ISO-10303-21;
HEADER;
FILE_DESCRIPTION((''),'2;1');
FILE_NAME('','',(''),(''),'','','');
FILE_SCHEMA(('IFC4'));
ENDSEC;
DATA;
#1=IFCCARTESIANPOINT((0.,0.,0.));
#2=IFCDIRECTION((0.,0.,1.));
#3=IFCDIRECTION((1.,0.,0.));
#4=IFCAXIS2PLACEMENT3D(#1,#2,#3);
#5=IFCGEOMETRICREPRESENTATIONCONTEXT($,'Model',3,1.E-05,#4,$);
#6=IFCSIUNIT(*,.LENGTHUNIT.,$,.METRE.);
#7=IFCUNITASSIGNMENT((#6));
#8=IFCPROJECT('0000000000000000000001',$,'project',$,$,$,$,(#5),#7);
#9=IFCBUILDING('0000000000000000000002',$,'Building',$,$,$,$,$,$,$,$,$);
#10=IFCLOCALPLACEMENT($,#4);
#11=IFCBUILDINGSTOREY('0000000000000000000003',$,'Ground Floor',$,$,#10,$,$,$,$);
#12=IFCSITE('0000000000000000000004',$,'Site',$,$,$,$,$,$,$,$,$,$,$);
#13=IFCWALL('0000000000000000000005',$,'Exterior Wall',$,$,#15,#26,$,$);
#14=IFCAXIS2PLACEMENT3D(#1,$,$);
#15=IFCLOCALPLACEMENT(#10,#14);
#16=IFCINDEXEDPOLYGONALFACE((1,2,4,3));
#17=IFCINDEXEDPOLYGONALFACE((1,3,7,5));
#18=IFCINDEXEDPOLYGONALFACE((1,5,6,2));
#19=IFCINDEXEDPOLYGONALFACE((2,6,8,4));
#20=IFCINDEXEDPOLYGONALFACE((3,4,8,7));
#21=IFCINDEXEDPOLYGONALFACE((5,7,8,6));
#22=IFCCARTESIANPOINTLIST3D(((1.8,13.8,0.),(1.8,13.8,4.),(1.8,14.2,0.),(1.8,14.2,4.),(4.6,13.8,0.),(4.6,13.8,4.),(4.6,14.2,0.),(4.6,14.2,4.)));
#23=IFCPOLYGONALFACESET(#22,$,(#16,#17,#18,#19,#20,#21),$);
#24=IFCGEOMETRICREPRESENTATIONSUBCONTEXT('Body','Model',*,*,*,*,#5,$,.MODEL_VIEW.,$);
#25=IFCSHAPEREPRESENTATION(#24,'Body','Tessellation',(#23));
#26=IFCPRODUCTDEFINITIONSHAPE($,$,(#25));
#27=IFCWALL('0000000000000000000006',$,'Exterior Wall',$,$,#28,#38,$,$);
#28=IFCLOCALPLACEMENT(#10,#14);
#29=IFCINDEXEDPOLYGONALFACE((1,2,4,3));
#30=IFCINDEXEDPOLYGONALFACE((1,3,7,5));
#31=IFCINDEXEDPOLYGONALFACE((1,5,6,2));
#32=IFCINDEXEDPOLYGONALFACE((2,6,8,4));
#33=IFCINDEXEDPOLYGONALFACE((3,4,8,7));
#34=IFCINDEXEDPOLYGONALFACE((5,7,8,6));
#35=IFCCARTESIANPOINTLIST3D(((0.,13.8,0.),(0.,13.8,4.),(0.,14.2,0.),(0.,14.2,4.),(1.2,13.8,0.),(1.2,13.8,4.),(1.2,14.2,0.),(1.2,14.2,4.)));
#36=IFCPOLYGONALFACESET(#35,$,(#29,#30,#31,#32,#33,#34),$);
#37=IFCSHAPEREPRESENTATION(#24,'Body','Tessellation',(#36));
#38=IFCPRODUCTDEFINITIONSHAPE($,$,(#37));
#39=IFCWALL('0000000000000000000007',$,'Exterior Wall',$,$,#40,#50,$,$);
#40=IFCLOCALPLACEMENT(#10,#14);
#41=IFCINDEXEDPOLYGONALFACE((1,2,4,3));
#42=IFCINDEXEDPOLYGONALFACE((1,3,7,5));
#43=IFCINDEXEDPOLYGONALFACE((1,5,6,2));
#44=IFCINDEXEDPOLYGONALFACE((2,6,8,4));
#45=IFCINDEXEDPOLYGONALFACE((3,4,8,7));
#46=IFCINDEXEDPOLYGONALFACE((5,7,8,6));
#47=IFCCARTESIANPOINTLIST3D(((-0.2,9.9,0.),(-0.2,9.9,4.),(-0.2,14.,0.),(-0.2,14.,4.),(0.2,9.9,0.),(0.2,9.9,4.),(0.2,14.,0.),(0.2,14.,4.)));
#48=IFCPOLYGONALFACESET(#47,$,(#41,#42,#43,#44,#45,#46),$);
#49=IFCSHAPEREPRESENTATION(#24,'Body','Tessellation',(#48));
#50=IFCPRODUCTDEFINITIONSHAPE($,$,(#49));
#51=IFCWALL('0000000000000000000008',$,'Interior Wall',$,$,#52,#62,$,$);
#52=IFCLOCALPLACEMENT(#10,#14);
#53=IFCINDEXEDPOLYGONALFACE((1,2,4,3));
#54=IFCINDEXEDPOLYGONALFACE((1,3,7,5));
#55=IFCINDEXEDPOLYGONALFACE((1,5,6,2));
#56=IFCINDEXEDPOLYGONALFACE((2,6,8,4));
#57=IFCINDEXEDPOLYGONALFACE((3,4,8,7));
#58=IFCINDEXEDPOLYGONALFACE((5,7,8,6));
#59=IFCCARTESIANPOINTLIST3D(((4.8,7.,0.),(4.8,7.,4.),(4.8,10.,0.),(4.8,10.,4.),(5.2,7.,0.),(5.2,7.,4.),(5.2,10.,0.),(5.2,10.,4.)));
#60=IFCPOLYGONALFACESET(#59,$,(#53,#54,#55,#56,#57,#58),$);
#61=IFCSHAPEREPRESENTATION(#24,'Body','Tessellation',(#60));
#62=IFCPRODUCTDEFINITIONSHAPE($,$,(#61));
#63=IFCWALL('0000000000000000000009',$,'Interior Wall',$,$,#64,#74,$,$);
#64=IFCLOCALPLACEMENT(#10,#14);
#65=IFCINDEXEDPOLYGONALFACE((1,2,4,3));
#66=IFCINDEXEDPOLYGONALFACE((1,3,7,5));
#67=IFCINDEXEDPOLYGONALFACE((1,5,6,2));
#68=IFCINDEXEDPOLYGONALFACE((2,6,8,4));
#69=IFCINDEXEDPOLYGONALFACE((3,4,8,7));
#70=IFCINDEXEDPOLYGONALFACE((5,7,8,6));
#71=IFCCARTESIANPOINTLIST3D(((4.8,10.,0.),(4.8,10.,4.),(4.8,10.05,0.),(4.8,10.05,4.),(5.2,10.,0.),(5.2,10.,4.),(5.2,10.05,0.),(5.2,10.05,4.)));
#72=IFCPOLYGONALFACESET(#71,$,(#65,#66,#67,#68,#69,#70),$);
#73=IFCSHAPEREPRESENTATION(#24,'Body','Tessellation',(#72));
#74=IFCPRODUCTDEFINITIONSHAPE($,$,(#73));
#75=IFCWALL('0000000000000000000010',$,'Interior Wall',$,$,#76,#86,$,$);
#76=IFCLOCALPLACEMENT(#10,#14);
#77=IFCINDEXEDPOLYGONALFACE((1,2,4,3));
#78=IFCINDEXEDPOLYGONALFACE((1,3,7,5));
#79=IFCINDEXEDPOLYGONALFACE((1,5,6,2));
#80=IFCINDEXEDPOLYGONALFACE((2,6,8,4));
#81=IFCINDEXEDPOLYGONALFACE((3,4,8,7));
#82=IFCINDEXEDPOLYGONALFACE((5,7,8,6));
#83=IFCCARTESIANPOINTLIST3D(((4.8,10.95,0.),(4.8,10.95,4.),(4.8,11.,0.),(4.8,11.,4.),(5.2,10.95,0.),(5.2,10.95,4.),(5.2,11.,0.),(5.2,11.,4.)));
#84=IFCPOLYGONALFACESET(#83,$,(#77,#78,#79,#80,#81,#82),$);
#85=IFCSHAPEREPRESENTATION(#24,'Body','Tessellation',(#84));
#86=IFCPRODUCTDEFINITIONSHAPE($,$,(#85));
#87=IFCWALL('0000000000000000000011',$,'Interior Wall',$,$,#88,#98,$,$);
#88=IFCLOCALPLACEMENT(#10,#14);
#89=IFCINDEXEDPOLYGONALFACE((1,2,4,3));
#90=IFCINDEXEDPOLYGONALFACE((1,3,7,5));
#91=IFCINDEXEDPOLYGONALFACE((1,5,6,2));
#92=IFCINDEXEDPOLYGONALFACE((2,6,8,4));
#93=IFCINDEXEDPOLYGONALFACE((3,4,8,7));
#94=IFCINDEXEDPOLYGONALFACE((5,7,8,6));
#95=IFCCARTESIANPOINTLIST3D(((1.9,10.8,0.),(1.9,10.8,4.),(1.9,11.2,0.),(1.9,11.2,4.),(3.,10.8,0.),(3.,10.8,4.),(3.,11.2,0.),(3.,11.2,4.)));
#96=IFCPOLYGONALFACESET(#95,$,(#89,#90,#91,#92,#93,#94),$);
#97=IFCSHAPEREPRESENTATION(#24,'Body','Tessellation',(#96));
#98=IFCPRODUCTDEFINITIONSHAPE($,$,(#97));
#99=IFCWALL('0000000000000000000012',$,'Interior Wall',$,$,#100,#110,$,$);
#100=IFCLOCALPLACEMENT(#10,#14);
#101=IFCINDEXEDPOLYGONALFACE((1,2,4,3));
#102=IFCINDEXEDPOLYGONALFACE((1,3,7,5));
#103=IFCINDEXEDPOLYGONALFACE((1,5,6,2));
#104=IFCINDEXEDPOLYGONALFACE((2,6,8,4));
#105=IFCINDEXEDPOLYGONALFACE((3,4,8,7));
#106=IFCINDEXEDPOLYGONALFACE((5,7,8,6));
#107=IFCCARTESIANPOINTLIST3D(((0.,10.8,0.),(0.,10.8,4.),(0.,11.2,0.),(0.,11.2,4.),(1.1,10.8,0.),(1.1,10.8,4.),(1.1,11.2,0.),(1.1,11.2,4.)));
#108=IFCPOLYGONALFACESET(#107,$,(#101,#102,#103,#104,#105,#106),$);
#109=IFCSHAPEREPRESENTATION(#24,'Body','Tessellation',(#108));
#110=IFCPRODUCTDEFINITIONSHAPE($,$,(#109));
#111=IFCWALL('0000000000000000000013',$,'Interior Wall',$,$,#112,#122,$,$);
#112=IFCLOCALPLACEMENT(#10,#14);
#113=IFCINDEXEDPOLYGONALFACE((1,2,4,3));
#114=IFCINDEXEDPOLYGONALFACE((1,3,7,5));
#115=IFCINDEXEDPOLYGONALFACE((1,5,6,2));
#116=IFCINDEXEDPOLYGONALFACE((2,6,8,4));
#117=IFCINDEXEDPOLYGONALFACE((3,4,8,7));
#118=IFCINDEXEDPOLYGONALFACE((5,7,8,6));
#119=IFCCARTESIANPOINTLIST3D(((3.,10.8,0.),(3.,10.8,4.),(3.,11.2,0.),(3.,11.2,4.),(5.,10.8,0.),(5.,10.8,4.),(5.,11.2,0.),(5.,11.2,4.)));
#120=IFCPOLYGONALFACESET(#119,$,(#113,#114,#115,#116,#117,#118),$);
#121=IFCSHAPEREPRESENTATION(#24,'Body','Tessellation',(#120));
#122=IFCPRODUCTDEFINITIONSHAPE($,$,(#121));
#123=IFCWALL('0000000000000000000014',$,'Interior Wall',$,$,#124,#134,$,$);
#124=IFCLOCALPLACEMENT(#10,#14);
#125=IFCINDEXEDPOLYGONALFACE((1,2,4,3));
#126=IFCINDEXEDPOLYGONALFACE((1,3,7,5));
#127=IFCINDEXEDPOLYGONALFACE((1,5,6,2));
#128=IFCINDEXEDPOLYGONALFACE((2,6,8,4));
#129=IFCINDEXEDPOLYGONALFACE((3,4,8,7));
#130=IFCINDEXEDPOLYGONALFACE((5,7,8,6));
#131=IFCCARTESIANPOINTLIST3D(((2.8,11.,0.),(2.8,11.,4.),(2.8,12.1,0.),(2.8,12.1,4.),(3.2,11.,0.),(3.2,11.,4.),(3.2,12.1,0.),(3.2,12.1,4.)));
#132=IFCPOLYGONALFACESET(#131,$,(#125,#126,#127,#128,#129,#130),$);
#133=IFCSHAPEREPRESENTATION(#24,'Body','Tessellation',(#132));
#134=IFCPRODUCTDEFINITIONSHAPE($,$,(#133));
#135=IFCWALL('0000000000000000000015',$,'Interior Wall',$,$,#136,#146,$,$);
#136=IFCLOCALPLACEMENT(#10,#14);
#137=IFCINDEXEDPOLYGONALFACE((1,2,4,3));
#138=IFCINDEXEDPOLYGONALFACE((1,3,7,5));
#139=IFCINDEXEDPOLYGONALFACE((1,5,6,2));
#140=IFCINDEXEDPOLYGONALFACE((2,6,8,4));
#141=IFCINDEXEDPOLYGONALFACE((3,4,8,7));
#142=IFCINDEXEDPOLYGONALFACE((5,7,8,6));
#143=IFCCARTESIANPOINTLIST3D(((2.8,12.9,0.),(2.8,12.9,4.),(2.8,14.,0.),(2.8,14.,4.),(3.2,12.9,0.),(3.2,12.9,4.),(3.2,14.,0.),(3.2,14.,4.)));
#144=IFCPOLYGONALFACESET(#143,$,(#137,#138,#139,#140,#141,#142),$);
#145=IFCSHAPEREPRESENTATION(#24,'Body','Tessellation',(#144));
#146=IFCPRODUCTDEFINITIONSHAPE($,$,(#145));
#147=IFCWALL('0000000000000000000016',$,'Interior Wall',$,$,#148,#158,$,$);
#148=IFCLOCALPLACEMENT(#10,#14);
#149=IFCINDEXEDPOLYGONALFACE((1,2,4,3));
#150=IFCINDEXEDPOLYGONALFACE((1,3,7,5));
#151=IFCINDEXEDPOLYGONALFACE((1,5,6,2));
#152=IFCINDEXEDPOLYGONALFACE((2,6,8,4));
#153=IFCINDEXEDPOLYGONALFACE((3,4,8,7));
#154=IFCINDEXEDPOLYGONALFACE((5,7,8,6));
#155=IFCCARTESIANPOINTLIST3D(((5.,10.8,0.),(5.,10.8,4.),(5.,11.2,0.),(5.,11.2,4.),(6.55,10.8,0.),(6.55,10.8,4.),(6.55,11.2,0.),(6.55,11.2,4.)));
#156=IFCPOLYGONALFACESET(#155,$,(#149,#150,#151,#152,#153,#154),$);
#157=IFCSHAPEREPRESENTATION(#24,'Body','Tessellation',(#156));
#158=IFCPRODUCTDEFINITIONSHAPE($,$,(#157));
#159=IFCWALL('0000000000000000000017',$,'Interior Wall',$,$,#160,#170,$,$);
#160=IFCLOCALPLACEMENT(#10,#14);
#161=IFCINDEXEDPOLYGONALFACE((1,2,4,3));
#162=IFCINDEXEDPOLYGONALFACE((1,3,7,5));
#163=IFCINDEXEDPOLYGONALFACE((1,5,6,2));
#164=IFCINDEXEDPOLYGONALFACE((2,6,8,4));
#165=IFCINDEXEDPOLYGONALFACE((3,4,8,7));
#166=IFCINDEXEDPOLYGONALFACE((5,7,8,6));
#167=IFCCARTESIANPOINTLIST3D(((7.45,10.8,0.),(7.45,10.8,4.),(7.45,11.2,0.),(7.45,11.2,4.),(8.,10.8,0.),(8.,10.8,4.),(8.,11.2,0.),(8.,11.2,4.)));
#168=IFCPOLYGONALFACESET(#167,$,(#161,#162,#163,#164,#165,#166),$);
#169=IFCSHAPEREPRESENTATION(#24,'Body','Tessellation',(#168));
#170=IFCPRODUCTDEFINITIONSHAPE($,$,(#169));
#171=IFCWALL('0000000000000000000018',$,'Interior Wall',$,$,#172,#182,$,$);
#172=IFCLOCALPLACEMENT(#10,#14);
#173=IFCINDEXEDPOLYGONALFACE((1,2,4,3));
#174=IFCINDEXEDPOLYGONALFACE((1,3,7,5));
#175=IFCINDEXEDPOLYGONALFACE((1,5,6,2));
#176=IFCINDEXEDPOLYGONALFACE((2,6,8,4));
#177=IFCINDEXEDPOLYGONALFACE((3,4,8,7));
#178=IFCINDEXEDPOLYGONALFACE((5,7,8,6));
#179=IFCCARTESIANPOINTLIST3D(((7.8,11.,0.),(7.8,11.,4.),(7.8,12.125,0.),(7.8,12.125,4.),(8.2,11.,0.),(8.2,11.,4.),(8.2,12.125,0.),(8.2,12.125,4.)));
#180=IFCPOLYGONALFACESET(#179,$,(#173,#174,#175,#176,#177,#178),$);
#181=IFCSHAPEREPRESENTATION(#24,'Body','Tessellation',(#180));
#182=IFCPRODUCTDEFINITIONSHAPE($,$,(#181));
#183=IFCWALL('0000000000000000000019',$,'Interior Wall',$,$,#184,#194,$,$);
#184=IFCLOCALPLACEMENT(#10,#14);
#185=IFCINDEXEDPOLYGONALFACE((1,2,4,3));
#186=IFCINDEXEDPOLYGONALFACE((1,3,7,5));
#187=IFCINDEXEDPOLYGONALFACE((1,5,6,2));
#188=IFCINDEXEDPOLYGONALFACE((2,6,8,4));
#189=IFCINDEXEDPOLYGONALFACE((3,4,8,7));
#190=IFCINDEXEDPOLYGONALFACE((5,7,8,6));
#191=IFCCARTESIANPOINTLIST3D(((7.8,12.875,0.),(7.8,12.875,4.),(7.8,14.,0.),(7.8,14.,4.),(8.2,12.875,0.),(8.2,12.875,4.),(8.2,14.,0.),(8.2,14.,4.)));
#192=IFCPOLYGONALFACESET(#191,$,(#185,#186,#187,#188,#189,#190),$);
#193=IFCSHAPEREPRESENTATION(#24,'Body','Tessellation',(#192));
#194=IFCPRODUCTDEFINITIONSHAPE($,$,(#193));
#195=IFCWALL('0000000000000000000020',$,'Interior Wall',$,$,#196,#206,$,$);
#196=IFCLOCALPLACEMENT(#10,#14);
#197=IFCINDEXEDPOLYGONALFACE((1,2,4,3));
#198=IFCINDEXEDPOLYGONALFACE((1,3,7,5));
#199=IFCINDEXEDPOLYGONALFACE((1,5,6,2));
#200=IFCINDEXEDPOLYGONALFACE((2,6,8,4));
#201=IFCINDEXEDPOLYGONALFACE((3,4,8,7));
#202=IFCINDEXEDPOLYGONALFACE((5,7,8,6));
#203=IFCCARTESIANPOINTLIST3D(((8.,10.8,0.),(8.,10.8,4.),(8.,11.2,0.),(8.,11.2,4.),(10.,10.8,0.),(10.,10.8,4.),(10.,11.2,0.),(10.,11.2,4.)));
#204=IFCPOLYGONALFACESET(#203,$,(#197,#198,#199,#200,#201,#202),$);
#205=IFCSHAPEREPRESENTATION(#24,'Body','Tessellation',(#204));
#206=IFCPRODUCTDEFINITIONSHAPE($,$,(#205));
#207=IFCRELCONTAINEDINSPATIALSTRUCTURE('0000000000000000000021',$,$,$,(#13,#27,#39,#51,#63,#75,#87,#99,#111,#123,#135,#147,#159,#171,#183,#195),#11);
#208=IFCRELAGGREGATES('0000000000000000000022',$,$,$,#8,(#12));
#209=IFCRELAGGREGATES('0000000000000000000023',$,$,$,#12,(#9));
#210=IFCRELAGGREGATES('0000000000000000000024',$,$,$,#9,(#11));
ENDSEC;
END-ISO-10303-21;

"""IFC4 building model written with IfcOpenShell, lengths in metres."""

from ifc_helpers import new_model, si_unit, frame, origin_with_axes, place, context, subcontext, project, spatial, indexed_curve, outline, extrude, element, save


model = new_model("IFC4")

# Units and contexts
model_context = context("Model", 3, precision=1e-05, world=origin_with_axes())
body_context = subcontext(model_context, "Body", "Model", "MODEL_VIEW")
ifc_project = project(units=[si_unit("LENGTHUNIT", "METRE")], contexts=[model_context])

# Site, building, storey
site = spatial("IfcSite", under=ifc_project, Name="Site")
building = spatial("IfcBuilding", under=site, Name="Building")
storey_placement = place(None, origin_with_axes())
storey = spatial("IfcBuildingStorey", under=building, at=storey_placement, Name="Ground Floor")

# Walls
wall_1_placement = place(storey_placement, frame((4.6, 14.0, 0.0), z_axis=(0.0, 0.0, 1.0), x_axis=(-1.0, 0.0, 0.0)))
element("IfcWall", 1, at=wall_1_placement, inside=storey, Name="Exterior Wall", context=body_context, shape_type="SweptSolid", body=[
    extrude(outline(indexed_curve([(0.0, 0.0), (0.0, 0.4), (2.8, 0.4), (2.8, 0.0), (0.0, 0.0)], self_intersect=False)), frame((0.0, -0.2, 0.0), z_axis=(0.0, 0.0, 1.0), x_axis=(1.0, 0.0, 0.0)), (0.0, 0.0, 1.0), 4.0),
])
wall_2_placement = place(storey_placement, frame((1.2, 14.0, 0.0), z_axis=(0.0, 0.0, 1.0), x_axis=(-1.0, 0.0, 0.0)))
element("IfcWall", 2, at=wall_2_placement, inside=storey, Name="Exterior Wall", context=body_context, shape_type="SweptSolid", body=[
    extrude(outline(indexed_curve([(0.0, 0.0), (0.0, 0.4), (1.2, 0.4), (1.2, 0.0), (0.0, 0.0)], self_intersect=False)), frame((0.0, -0.2, 0.0), z_axis=(0.0, 0.0, 1.0), x_axis=(1.0, 0.0, 0.0)), (0.0, 0.0, 1.0), 4.0),
])
wall_3_placement = place(storey_placement, frame((0.0, 14.0, 0.0), z_axis=(0.0, 0.0, 1.0), x_axis=(0.0, -1.0, 0.0)))
element("IfcWall", 3, at=wall_3_placement, inside=storey, Name="Exterior Wall", context=body_context, shape_type="SweptSolid", body=[
    extrude(outline(indexed_curve([(0.0, 0.0), (0.0, 0.4), (4.1, 0.4), (4.1, 0.0), (0.0, 0.0)], self_intersect=False)), frame((0.0, -0.2, 0.0), z_axis=(0.0, 0.0, 1.0), x_axis=(1.0, 0.0, 0.0)), (0.0, 0.0, 1.0), 4.0),
])
wall_4_placement = place(storey_placement, frame((5.0, 10.0, 0.0), z_axis=(0.0, 0.0, 1.0), x_axis=(0.0, -1.0, 0.0)))
element("IfcWall", 4, at=wall_4_placement, inside=storey, Name="Interior Wall", context=body_context, shape_type="SweptSolid", body=[
    extrude(outline(indexed_curve([(0.0, 0.0), (0.0, 0.4), (3.0, 0.4), (3.0, 0.0), (0.0, 0.0)], self_intersect=False)), frame((0.0, -0.2, 0.0), z_axis=(0.0, 0.0, 1.0), x_axis=(1.0, 0.0, 0.0)), (0.0, 0.0, 1.0), 4.0),
])
for number, where, z_axis, x_axis, name in (
    (5, (5.0, 10.0, 0.0), (0.0, 0.0, 1.0), (0.0, 1.0, 0.0), "Interior Wall"),
    (6, (5.0, 10.95, 0.0), (0.0, 0.0, 1.0), (0.0, 1.0, 0.0), "Interior Wall"),
):
    element("IfcWall", number, at=place(storey_placement, frame(where, z_axis=z_axis, x_axis=x_axis)), inside=storey, Name=name, context=body_context, shape_type="SweptSolid", body=[
        extrude(outline(indexed_curve([(0.0, 0.0), (0.0, 0.4), (0.05, 0.4), (0.05, 0.0), (0.0, 0.0)], self_intersect=False)), frame((0.0, -0.2, 0.0), z_axis=(0.0, 0.0, 1.0), x_axis=(1.0, 0.0, 0.0)), (0.0, 0.0, 1.0), 4.0),
    ])
for number, where, z_axis, x_axis, name in (
    (7, (3.0, 11.0, 0.0), (0.0, 0.0, 1.0), (-1.0, 0.0, 0.0), "Interior Wall"),
    (8, (1.1, 11.0, 0.0), (0.0, 0.0, 1.0), (-1.0, 0.0, 0.0), "Interior Wall"),
):
    element("IfcWall", number, at=place(storey_placement, frame(where, z_axis=z_axis, x_axis=x_axis)), inside=storey, Name=name, context=body_context, shape_type="SweptSolid", body=[
        extrude(outline(indexed_curve([(0.0, 0.0), (0.0, 0.4), (1.1, 0.4), (1.1, 0.0), (0.0, 0.0)], self_intersect=False)), frame((0.0, -0.2, 0.0), z_axis=(0.0, 0.0, 1.0), x_axis=(1.0, 0.0, 0.0)), (0.0, 0.0, 1.0), 4.0),
    ])
wall_5_placement = place(storey_placement, frame((5.0, 11.0, 0.0), z_axis=(0.0, 0.0, 1.0), x_axis=(-1.0, 0.0, 0.0)))
element("IfcWall", 9, at=wall_5_placement, inside=storey, Name="Interior Wall", context=body_context, shape_type="SweptSolid", body=[
    extrude(outline(indexed_curve([(0.0, 0.0), (0.0, 0.4), (2.0, 0.4), (2.0, 0.0), (0.0, 0.0)], self_intersect=False)), frame((0.0, -0.2, 0.0), z_axis=(0.0, 0.0, 1.0), x_axis=(1.0, 0.0, 0.0)), (0.0, 0.0, 1.0), 4.0),
])
for number, where, z_axis, x_axis, name in (
    (10, (3.0, 11.0, 0.0), (0.0, 0.0, 1.0), (0.0, 1.0, 0.0), "Interior Wall"),
    (11, (3.0, 12.9, 0.0), (0.0, 0.0, 1.0), (0.0, 1.0, 0.0), "Interior Wall"),
):
    element("IfcWall", number, at=place(storey_placement, frame(where, z_axis=z_axis, x_axis=x_axis)), inside=storey, Name=name, context=body_context, shape_type="SweptSolid", body=[
        extrude(outline(indexed_curve([(0.0, 0.0), (0.0, 0.4), (1.1, 0.4), (1.1, 0.0), (0.0, 0.0)], self_intersect=False)), frame((0.0, -0.2, 0.0), z_axis=(0.0, 0.0, 1.0), x_axis=(1.0, 0.0, 0.0)), (0.0, 0.0, 1.0), 4.0),
    ])
wall_6_placement = place(storey_placement, frame((5.0, 11.0, 0.0), z_axis=(0.0, 0.0, 1.0), x_axis=(1.0, 0.0, 0.0)))
element("IfcWall", 12, at=wall_6_placement, inside=storey, Name="Interior Wall", context=body_context, shape_type="SweptSolid", body=[
    extrude(outline(indexed_curve([(0.0, 0.0), (0.0, 0.4), (1.55, 0.4), (1.55, 0.0), (0.0, 0.0)], self_intersect=False)), frame((0.0, -0.2, 0.0), z_axis=(0.0, 0.0, 1.0), x_axis=(1.0, 0.0, 0.0)), (0.0, 0.0, 1.0), 4.0),
])
wall_7_placement = place(storey_placement, frame((7.45, 11.0, 0.0), z_axis=(0.0, 0.0, 1.0), x_axis=(1.0, 0.0, 0.0)))
element("IfcWall", 13, at=wall_7_placement, inside=storey, Name="Interior Wall", context=body_context, shape_type="SweptSolid", body=[
    extrude(outline(indexed_curve([(0.0, 0.0), (0.0, 0.4), (0.55, 0.4), (0.55, 0.0), (0.0, 0.0)], self_intersect=False)), frame((0.0, -0.2, 0.0), z_axis=(0.0, 0.0, 1.0), x_axis=(1.0, 0.0, 0.0)), (0.0, 0.0, 1.0), 4.0),
])
for number, where, z_axis, x_axis, name in (
    (14, (8.0, 11.0, 0.0), (0.0, 0.0, 1.0), (0.0, 1.0, 0.0), "Interior Wall"),
    (15, (8.0, 12.875, 0.0), (0.0, 0.0, 1.0), (0.0, 1.0, 0.0), "Interior Wall"),
):
    element("IfcWall", number, at=place(storey_placement, frame(where, z_axis=z_axis, x_axis=x_axis)), inside=storey, Name=name, context=body_context, shape_type="SweptSolid", body=[
        extrude(outline(indexed_curve([(0.0, 0.0), (0.0, 0.4), (1.125, 0.4), (1.125, 0.0), (0.0, 0.0)], self_intersect=False)), frame((0.0, -0.2, 0.0), z_axis=(0.0, 0.0, 1.0), x_axis=(1.0, 0.0, 0.0)), (0.0, 0.0, 1.0), 4.0),
    ])
wall_8_placement = place(storey_placement, frame((8.0, 11.0, 0.0), z_axis=(0.0, 0.0, 1.0), x_axis=(1.0, 0.0, 0.0)))
element("IfcWall", 16, at=wall_8_placement, inside=storey, Name="Interior Wall", context=body_context, shape_type="SweptSolid", body=[
    extrude(outline(indexed_curve([(0.0, 0.0), (0.0, 0.4), (2.0, 0.4), (2.0, 0.0), (0.0, 0.0)], self_intersect=False)), frame((0.0, -0.2, 0.0), z_axis=(0.0, 0.0, 1.0), x_axis=(1.0, 0.0, 0.0)), (0.0, 0.0, 1.0), 4.0),
])

save(model, "model.ifc")
